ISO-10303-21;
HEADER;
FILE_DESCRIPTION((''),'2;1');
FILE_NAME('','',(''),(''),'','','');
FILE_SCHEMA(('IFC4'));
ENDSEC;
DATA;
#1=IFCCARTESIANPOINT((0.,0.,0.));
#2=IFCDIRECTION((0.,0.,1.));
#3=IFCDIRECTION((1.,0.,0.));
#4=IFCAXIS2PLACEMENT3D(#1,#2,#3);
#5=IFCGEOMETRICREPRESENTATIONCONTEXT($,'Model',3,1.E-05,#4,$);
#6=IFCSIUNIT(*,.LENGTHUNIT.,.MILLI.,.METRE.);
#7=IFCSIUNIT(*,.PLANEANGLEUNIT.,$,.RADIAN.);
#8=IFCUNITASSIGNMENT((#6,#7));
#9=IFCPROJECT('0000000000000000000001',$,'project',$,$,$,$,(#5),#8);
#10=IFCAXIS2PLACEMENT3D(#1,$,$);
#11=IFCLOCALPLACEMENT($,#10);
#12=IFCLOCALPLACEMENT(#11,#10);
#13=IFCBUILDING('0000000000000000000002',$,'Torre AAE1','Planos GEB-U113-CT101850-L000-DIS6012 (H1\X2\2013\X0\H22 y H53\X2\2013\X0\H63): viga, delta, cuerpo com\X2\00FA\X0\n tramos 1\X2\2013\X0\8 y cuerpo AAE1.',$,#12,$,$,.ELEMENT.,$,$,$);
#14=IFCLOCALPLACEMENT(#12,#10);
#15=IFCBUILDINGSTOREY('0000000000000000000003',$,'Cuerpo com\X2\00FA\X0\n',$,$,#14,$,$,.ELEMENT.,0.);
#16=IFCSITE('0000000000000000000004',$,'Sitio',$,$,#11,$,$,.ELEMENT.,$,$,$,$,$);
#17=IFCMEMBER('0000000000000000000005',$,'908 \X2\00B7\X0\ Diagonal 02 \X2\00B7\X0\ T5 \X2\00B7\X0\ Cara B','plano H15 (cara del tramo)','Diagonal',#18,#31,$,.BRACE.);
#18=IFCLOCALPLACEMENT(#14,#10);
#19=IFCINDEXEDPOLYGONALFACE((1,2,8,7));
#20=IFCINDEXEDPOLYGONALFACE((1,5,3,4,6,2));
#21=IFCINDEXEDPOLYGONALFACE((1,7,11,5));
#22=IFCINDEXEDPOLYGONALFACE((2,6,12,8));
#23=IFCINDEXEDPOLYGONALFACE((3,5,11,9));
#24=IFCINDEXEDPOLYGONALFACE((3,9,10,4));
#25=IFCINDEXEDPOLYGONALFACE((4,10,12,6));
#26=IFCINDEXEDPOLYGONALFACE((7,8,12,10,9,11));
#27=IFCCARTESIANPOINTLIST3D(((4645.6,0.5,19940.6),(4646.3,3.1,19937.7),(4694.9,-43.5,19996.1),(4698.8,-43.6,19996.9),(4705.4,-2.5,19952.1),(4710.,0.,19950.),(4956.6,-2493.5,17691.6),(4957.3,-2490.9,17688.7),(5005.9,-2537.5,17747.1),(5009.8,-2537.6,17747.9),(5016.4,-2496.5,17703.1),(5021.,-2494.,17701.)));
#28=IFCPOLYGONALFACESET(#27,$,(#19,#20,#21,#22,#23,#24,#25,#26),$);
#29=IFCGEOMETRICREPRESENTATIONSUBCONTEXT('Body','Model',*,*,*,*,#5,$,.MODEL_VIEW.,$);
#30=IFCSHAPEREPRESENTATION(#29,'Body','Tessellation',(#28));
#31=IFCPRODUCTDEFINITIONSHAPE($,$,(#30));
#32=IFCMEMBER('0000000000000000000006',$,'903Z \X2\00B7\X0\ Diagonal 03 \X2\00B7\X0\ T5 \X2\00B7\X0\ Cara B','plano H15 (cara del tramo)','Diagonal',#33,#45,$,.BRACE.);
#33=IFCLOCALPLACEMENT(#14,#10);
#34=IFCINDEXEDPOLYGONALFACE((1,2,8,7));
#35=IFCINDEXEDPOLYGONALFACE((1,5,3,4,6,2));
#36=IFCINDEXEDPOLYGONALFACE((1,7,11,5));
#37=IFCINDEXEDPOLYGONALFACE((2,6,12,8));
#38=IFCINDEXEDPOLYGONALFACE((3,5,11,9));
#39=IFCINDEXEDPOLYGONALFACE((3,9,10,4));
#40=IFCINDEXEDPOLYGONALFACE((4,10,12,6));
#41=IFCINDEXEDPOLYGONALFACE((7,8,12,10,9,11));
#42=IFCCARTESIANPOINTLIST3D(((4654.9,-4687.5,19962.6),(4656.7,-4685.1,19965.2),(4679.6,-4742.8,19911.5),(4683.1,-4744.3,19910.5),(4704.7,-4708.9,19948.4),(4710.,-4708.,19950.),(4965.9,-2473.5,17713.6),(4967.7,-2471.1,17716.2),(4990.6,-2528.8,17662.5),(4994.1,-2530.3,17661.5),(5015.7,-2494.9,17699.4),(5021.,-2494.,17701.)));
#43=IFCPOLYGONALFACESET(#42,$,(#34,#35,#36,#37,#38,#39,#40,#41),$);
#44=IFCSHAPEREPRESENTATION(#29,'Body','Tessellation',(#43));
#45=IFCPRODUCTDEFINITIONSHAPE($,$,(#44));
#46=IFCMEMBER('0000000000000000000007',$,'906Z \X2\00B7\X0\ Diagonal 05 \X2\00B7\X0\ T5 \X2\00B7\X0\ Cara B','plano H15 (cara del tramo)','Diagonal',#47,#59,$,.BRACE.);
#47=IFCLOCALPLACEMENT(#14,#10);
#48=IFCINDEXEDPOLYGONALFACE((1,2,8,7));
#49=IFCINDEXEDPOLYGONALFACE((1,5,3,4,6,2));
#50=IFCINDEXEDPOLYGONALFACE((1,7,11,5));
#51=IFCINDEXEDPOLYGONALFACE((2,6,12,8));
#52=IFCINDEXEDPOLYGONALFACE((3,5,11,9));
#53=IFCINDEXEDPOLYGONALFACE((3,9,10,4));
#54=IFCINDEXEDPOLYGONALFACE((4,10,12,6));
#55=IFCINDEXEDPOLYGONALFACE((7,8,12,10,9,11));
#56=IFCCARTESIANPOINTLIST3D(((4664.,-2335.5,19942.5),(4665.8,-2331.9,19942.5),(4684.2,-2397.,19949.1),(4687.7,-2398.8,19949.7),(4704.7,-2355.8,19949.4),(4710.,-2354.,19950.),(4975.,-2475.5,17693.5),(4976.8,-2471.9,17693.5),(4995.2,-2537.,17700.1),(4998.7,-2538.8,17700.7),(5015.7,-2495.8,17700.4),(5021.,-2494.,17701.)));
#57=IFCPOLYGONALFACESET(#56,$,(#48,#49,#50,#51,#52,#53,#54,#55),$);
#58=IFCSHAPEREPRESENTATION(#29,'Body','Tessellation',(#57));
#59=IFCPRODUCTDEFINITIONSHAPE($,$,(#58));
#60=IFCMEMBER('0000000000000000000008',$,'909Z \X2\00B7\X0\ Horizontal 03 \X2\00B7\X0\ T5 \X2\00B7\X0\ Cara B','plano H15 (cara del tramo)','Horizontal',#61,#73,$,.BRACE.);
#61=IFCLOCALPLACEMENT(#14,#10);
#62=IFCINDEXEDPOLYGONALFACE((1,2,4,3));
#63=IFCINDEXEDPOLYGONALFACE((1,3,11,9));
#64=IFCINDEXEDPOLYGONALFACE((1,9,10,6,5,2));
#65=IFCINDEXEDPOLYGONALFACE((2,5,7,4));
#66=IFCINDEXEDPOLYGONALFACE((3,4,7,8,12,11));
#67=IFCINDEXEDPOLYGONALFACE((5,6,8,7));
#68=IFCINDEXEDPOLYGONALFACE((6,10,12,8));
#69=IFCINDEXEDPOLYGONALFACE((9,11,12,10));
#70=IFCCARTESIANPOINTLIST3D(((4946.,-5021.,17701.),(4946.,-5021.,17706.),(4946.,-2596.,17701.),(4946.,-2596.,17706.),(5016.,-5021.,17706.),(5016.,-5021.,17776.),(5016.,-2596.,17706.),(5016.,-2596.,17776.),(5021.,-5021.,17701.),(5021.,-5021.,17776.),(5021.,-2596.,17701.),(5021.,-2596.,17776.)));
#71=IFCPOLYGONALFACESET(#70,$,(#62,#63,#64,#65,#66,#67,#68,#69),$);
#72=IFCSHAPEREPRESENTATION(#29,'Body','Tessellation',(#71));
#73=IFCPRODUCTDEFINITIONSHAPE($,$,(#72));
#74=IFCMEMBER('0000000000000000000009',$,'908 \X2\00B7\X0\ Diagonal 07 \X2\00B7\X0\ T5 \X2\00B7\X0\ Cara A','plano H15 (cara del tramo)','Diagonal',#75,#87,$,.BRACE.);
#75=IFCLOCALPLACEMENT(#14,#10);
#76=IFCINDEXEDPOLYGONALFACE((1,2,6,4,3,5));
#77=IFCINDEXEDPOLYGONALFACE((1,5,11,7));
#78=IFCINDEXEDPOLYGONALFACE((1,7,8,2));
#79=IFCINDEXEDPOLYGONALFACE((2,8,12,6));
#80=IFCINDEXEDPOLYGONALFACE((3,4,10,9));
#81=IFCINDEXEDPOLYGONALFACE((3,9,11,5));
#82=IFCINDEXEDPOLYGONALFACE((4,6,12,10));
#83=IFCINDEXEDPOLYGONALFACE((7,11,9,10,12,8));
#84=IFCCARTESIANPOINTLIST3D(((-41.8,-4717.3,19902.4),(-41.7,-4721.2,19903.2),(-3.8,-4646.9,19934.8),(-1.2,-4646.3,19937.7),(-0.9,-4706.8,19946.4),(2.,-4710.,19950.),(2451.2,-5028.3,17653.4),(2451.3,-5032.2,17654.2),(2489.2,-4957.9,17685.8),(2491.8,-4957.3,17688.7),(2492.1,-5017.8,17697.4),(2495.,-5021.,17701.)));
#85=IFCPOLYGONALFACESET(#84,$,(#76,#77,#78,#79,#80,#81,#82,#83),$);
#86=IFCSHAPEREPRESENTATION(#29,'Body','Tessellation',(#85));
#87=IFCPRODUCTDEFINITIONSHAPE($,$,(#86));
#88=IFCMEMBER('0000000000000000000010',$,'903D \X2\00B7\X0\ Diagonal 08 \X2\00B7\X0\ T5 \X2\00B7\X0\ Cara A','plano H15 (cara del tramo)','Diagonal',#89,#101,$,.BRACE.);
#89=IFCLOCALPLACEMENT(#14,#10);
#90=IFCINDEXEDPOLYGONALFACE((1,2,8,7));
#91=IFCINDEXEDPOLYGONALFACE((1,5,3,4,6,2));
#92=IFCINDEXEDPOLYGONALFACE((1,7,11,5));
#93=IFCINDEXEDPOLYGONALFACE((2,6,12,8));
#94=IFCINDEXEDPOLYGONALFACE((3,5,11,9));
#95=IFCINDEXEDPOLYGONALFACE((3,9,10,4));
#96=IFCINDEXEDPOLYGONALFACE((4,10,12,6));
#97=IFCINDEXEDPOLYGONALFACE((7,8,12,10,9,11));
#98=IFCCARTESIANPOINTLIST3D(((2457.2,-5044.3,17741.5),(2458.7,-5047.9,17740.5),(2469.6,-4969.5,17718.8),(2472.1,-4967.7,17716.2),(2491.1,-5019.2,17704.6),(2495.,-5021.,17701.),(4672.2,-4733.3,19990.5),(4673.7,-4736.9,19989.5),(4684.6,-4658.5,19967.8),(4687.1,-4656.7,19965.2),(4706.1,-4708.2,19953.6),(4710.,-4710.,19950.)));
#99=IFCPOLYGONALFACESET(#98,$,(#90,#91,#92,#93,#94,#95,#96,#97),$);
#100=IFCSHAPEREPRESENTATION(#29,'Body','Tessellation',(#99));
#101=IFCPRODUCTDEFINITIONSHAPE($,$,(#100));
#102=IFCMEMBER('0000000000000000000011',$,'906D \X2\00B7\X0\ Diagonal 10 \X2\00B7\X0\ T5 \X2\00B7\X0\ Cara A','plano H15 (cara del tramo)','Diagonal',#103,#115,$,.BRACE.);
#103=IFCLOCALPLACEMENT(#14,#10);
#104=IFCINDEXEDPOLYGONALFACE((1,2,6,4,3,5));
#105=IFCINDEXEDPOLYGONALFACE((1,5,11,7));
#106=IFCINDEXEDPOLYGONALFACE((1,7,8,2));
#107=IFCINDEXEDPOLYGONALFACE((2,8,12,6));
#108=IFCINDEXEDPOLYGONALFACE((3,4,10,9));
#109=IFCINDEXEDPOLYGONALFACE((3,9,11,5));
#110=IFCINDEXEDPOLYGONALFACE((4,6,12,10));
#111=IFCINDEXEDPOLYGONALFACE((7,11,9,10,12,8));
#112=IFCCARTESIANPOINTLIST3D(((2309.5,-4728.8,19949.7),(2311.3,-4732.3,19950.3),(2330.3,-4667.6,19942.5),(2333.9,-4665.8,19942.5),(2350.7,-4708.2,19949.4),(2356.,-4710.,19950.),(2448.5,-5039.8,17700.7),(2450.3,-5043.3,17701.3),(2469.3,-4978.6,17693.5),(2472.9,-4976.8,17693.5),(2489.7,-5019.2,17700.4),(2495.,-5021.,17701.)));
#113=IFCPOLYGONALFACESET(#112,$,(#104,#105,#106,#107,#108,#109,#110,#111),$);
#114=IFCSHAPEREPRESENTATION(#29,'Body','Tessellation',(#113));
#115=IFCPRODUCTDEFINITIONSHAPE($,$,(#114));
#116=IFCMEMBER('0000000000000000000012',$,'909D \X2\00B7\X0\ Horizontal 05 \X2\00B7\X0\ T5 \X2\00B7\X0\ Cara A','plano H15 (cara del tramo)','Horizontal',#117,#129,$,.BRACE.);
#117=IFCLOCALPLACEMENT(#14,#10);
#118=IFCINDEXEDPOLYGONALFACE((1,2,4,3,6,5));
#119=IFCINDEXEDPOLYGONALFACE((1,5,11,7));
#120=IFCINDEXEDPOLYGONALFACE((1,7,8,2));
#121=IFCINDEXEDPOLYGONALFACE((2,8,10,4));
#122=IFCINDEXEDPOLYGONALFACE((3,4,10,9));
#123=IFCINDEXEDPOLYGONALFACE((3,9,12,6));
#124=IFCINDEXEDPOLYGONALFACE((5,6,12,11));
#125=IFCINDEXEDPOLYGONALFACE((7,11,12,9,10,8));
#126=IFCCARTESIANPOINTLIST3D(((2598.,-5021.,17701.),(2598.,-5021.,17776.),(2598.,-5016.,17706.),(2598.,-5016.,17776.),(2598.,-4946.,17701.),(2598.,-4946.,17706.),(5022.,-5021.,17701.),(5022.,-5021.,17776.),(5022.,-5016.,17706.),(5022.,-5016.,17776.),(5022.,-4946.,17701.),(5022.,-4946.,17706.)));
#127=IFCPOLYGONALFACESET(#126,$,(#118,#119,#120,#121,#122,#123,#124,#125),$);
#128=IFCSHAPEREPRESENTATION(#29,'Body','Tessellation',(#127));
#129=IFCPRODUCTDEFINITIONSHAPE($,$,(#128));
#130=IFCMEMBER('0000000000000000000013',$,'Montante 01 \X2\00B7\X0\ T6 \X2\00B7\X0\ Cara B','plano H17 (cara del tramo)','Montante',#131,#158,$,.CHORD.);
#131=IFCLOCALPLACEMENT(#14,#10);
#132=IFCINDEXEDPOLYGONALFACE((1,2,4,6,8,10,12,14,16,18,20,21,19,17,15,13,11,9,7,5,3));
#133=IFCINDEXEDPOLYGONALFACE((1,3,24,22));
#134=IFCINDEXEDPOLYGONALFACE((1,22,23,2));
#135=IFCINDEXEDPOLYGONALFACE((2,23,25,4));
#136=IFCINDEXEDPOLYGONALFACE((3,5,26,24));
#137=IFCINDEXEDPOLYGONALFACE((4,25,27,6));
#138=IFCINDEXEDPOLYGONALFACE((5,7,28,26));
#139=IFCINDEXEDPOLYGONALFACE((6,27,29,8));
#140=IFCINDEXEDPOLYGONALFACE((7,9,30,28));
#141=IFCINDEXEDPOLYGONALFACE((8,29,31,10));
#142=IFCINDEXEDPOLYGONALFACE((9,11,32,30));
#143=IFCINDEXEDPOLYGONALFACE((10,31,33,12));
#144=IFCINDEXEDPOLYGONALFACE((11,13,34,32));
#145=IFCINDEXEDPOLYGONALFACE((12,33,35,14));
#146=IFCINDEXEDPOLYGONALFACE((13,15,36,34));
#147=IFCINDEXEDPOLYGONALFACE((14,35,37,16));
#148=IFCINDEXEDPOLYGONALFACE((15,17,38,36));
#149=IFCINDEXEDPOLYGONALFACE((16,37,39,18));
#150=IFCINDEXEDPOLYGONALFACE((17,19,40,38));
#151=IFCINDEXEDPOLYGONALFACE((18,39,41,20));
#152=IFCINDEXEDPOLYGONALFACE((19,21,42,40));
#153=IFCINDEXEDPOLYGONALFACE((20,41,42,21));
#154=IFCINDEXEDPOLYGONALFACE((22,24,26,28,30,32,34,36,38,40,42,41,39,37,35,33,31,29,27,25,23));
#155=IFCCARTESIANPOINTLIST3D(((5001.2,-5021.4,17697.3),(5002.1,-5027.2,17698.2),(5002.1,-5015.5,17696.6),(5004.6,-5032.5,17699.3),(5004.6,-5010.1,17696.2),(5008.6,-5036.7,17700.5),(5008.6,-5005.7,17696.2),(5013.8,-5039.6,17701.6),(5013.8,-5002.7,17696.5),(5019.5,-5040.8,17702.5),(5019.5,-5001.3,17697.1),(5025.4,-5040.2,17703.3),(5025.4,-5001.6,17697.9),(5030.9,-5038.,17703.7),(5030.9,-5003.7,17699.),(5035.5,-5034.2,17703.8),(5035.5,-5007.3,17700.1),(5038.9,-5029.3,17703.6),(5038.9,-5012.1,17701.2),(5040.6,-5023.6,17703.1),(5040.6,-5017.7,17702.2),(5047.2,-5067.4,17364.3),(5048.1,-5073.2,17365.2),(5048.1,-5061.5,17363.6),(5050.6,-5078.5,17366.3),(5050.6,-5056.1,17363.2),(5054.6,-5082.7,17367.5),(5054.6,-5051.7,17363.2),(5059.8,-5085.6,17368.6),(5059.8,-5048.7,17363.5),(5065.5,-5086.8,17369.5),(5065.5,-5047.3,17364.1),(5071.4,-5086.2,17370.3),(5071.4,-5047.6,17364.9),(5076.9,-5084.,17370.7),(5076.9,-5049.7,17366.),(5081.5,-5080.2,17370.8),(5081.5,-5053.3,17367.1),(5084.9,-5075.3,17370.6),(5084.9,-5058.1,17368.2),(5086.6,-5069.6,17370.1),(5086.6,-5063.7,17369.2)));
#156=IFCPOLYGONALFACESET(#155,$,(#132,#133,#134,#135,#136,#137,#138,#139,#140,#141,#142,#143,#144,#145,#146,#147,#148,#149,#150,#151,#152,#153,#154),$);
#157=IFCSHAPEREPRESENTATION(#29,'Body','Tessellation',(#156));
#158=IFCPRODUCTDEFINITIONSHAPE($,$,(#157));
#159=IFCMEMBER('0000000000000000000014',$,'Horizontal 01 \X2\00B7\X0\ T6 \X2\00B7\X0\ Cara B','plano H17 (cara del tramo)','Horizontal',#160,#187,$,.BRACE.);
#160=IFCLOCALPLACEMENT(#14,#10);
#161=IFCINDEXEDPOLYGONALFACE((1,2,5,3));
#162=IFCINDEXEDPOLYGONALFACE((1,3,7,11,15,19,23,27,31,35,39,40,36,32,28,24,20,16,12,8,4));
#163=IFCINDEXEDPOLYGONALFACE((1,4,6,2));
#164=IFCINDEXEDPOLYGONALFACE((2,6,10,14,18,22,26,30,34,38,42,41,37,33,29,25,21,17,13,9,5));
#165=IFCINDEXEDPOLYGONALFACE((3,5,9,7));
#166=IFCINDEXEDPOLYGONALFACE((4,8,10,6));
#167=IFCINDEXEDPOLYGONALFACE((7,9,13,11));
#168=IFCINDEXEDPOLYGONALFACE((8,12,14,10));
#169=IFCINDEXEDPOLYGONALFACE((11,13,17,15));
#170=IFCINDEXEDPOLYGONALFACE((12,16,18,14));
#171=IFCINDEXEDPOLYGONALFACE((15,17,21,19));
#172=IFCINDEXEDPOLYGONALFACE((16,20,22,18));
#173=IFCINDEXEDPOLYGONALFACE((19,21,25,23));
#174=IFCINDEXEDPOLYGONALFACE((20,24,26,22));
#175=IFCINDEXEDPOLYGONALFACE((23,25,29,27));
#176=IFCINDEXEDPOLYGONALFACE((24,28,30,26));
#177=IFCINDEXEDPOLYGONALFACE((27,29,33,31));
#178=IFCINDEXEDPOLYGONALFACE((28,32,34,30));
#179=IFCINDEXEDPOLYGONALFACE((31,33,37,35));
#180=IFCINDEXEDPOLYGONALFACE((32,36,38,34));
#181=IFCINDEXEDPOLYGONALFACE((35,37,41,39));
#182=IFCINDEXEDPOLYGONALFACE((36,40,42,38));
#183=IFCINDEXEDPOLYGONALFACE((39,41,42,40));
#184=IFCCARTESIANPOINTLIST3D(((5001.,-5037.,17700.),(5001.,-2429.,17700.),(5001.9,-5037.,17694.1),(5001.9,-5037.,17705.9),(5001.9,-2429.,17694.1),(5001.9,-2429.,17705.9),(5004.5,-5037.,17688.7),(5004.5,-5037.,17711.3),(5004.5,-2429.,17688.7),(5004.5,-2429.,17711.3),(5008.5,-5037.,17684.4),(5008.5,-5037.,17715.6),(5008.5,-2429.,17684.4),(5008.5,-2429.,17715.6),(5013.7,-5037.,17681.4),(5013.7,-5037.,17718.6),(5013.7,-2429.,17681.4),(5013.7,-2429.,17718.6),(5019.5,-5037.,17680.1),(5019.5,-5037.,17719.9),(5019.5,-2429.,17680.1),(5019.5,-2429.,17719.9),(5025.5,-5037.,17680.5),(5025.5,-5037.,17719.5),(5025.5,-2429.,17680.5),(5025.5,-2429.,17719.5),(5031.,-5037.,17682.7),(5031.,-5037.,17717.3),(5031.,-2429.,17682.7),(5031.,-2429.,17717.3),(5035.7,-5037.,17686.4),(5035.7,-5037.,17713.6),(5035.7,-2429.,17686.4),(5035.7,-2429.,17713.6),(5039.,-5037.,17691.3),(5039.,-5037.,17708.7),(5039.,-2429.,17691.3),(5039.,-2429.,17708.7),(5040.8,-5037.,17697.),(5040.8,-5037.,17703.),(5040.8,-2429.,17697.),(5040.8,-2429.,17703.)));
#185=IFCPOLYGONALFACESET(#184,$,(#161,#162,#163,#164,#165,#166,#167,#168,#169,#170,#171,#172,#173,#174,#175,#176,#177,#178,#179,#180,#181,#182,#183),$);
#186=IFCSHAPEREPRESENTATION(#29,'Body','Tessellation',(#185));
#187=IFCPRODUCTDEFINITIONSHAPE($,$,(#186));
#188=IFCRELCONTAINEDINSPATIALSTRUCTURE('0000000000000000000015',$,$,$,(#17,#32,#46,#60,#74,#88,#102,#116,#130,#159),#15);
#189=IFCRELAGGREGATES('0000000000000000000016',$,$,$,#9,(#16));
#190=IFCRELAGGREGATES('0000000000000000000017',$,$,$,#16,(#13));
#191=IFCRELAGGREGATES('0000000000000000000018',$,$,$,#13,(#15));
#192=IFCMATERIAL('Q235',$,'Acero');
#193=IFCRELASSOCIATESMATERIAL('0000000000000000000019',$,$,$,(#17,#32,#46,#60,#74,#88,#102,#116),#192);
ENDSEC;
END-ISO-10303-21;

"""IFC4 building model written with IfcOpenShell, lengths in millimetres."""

from ifc_helpers import new_model, si_unit, frame, frame_2d, origin, origin_with_axes, place, context, subcontext, project, spatial, circle, l_section, extrude, material, element, save


model = new_model("IFC4")

# Units and contexts
model_context = context("Model", 3, precision=1e-05, world=origin_with_axes())
body_context = subcontext(model_context, "Body", "Model", "MODEL_VIEW")
ifc_project = project(units=[si_unit("LENGTHUNIT", "METRE", prefix="MILLI"), si_unit("PLANEANGLEUNIT", "RADIAN")], contexts=[model_context])

# Site, building, storey
site_placement = place(None, origin())
site = spatial("IfcSite", under=ifc_project, at=site_placement, Name="Sitio", CompositionType="ELEMENT")
building_placement = place(site_placement, origin())
building = spatial("IfcBuilding", under=site, at=building_placement, Name="Torre AAE1", Description="Planos GEB-U113-CT101850-L000-DIS6012 (H1–H22 y H53–H63): viga, delta, cuerpo común tramos 1–8 y cuerpo AAE1.", CompositionType="ELEMENT")
storey_placement = place(building_placement, origin())
storey = spatial("IfcBuildingStorey", under=building, at=storey_placement, Name="Cuerpo común", CompositionType="ELEMENT", Elevation=0.0)

# Members
ifc_material_1 = material(Name="Q235", Category="Acero")
member_1_placement = place(storey_placement, frame((5021.0, -2494.0, 17701.0), z_axis=(-0.092212, 0.739478, 0.666835), x_axis=(-0.980756, 0.048288, -0.189171)))
element("IfcMember", 1, at=member_1_placement, inside=storey, material=ifc_material_1, Name="908 · Diagonal 02 · T5 · Cara B", Description="plano H15 (cara del tramo)", ObjectType="Diagonal", PredefinedType="BRACE", context=body_context, shape_type="SweptSolid", body=[
    extrude(l_section(Depth=65.0, Width=65.0, Thickness=4.0, at=frame_2d((32.5, 32.5))), None, (0.0, 0.0, 1.0), 3372.6),
])
member_2_placement = place(storey_placement, frame((5021.0, -2494.0, 17701.0), z_axis=(-0.09807, -0.698158, 0.709195), x_axis=(-0.888624, 0.382258, 0.253427)))
element("IfcMember", 2, at=member_2_placement, inside=storey, material=ifc_material_1, Name="903Z · Diagonal 03 · T5 · Cara B", Description="plano H15 (cara del tramo)", ObjectType="Diagonal", PredefinedType="BRACE", context=body_context, shape_type="SweptSolid", body=[
    extrude(l_section(Depth=60.0, Width=60.0, Thickness=4.0, at=frame_2d((30.0, 30.0))), None, (0.0, 0.0, 1.0), 3171.2),
])
member_3_placement = place(storey_placement, frame((5021.0, -2494.0, 17701.0), z_axis=(-0.136721, 0.061546, 0.988696), x_axis=(-0.884571, 0.44169, -0.149817)))
element("IfcMember", 3, at=member_3_placement, inside=storey, material=ifc_material_1, Name="906Z · Diagonal 05 · T5 · Cara B", Description="plano H15 (cara del tramo)", ObjectType="Diagonal", PredefinedType="BRACE", context=body_context, shape_type="SweptSolid", body=[
    extrude(l_section(Depth=50.0, Width=50.0, Thickness=4.0, at=frame_2d((25.0, 25.0))), None, (0.0, 0.0, 1.0), 2274.7),
])
member_4_placement = place(storey_placement, frame((5021.0, -5021.0, 17701.0), z_axis=(0.0, 1.0, 0.0), x_axis=(-1.0, 0.0, 0.0)))
element("IfcMember", 4, at=member_4_placement, inside=storey, material=ifc_material_1, Name="909Z · Horizontal 03 · T5 · Cara B", Description="plano H15 (cara del tramo)", ObjectType="Horizontal", PredefinedType="BRACE", context=body_context, shape_type="SweptSolid", body=[
    extrude(l_section(Depth=75.0, Width=75.0, Thickness=5.0, at=frame_2d((37.5, 37.5))), None, (0.0, 0.0, 1.0), 2425.0),
])
member_5_placement = place(storey_placement, frame((2495.0, -5021.0, 17701.0), z_axis=(-0.739344, 0.092233, 0.666981), x_axis=(-0.048477, 0.980712, -0.189352)))
element("IfcMember", 5, at=member_5_placement, inside=storey, material=ifc_material_1, Name="908 · Diagonal 07 · T5 · Cara A", Description="plano H15 (cara del tramo)", ObjectType="Diagonal", PredefinedType="BRACE", context=body_context, shape_type="SweptSolid", body=[
    extrude(l_section(Depth=65.0, Width=65.0, Thickness=4.0, at=frame_2d((32.5, 32.5))), None, (0.0, 0.0, 1.0), 3371.9),
])
member_6_placement = place(storey_placement, frame((2495.0, -5021.0, 17701.0), z_axis=(0.69832, 0.098049, 0.709039), x_axis=(-0.382229, 0.888595, 0.253573)))
element("IfcMember", 6, at=member_6_placement, inside=storey, material=ifc_material_1, Name="903D · Diagonal 08 · T5 · Cara A", Description="plano H15 (cara del tramo)", ObjectType="Diagonal", PredefinedType="BRACE", context=body_context, shape_type="SweptSolid", body=[
    extrude(l_section(Depth=60.0, Width=60.0, Thickness=4.0, at=frame_2d((30.0, 30.0))), None, (0.0, 0.0, 1.0), 3171.9),
])
member_7_placement = place(storey_placement, frame((2495.0, -5021.0, 17701.0), z_axis=(-0.061108, 0.136724, 0.988723), x_axis=(-0.441979, 0.884459, -0.149623)))
element("IfcMember", 7, at=member_7_placement, inside=storey, material=ifc_material_1, Name="906D · Diagonal 10 · T5 · Cara A", Description="plano H15 (cara del tramo)", ObjectType="Diagonal", PredefinedType="BRACE", context=body_context, shape_type="SweptSolid", body=[
    extrude(l_section(Depth=50.0, Width=50.0, Thickness=4.0, at=frame_2d((25.0, 25.0))), None, (0.0, 0.0, 1.0), 2274.7),
])
member_8_placement = place(storey_placement, frame((2598.0, -5021.0, 17701.0), z_axis=(1.0, 0.0, 0.0), x_axis=(0.0, 1.0, 0.0)))
element("IfcMember", 8, at=member_8_placement, inside=storey, material=ifc_material_1, Name="909D · Horizontal 05 · T5 · Cara A", Description="plano H15 (cara del tramo)", ObjectType="Horizontal", PredefinedType="BRACE", context=body_context, shape_type="SweptSolid", body=[
    extrude(l_section(Depth=75.0, Width=75.0, Thickness=5.0, at=frame_2d((37.5, 37.5))), None, (0.0, 0.0, 1.0), 2424.0),
])
member_9_placement = place(storey_placement, frame((5021.0, -5021.0, 17700.0), z_axis=(0.135575, -0.135575, -0.981447), x_axis=(-0.990767, -0.018552, -0.1343)))
element("IfcMember", 9, at=member_9_placement, inside=storey, Name="Montante 01 · T6 · Cara B", Description="plano H17 (cara del tramo)", ObjectType="Montante", PredefinedType="CHORD", context=body_context, shape_type="SweptSolid", body=[
    extrude(circle(Radius=20.0), None, (0.0, 0.0, 1.0), 339.3),
])
for number, where, z_axis, x_axis, name in (
    (10, (5021.0, -5037.0, 17700.0), (0.0, 1.0, 0.0), (-1.0, 0.0, 0.0), "Horizontal 01 · T6 · Cara B"),
):
    element("IfcMember", number, at=place(storey_placement, frame(where, z_axis=z_axis, x_axis=x_axis)), inside=storey, Name=name, Description="plano H17 (cara del tramo)", ObjectType="Horizontal", PredefinedType="BRACE", context=body_context, shape_type="SweptSolid", body=[
        extrude(circle(Radius=20.0), None, (0.0, 0.0, 1.0), 2608.0),
    ])

save(model, "model.ifc")
